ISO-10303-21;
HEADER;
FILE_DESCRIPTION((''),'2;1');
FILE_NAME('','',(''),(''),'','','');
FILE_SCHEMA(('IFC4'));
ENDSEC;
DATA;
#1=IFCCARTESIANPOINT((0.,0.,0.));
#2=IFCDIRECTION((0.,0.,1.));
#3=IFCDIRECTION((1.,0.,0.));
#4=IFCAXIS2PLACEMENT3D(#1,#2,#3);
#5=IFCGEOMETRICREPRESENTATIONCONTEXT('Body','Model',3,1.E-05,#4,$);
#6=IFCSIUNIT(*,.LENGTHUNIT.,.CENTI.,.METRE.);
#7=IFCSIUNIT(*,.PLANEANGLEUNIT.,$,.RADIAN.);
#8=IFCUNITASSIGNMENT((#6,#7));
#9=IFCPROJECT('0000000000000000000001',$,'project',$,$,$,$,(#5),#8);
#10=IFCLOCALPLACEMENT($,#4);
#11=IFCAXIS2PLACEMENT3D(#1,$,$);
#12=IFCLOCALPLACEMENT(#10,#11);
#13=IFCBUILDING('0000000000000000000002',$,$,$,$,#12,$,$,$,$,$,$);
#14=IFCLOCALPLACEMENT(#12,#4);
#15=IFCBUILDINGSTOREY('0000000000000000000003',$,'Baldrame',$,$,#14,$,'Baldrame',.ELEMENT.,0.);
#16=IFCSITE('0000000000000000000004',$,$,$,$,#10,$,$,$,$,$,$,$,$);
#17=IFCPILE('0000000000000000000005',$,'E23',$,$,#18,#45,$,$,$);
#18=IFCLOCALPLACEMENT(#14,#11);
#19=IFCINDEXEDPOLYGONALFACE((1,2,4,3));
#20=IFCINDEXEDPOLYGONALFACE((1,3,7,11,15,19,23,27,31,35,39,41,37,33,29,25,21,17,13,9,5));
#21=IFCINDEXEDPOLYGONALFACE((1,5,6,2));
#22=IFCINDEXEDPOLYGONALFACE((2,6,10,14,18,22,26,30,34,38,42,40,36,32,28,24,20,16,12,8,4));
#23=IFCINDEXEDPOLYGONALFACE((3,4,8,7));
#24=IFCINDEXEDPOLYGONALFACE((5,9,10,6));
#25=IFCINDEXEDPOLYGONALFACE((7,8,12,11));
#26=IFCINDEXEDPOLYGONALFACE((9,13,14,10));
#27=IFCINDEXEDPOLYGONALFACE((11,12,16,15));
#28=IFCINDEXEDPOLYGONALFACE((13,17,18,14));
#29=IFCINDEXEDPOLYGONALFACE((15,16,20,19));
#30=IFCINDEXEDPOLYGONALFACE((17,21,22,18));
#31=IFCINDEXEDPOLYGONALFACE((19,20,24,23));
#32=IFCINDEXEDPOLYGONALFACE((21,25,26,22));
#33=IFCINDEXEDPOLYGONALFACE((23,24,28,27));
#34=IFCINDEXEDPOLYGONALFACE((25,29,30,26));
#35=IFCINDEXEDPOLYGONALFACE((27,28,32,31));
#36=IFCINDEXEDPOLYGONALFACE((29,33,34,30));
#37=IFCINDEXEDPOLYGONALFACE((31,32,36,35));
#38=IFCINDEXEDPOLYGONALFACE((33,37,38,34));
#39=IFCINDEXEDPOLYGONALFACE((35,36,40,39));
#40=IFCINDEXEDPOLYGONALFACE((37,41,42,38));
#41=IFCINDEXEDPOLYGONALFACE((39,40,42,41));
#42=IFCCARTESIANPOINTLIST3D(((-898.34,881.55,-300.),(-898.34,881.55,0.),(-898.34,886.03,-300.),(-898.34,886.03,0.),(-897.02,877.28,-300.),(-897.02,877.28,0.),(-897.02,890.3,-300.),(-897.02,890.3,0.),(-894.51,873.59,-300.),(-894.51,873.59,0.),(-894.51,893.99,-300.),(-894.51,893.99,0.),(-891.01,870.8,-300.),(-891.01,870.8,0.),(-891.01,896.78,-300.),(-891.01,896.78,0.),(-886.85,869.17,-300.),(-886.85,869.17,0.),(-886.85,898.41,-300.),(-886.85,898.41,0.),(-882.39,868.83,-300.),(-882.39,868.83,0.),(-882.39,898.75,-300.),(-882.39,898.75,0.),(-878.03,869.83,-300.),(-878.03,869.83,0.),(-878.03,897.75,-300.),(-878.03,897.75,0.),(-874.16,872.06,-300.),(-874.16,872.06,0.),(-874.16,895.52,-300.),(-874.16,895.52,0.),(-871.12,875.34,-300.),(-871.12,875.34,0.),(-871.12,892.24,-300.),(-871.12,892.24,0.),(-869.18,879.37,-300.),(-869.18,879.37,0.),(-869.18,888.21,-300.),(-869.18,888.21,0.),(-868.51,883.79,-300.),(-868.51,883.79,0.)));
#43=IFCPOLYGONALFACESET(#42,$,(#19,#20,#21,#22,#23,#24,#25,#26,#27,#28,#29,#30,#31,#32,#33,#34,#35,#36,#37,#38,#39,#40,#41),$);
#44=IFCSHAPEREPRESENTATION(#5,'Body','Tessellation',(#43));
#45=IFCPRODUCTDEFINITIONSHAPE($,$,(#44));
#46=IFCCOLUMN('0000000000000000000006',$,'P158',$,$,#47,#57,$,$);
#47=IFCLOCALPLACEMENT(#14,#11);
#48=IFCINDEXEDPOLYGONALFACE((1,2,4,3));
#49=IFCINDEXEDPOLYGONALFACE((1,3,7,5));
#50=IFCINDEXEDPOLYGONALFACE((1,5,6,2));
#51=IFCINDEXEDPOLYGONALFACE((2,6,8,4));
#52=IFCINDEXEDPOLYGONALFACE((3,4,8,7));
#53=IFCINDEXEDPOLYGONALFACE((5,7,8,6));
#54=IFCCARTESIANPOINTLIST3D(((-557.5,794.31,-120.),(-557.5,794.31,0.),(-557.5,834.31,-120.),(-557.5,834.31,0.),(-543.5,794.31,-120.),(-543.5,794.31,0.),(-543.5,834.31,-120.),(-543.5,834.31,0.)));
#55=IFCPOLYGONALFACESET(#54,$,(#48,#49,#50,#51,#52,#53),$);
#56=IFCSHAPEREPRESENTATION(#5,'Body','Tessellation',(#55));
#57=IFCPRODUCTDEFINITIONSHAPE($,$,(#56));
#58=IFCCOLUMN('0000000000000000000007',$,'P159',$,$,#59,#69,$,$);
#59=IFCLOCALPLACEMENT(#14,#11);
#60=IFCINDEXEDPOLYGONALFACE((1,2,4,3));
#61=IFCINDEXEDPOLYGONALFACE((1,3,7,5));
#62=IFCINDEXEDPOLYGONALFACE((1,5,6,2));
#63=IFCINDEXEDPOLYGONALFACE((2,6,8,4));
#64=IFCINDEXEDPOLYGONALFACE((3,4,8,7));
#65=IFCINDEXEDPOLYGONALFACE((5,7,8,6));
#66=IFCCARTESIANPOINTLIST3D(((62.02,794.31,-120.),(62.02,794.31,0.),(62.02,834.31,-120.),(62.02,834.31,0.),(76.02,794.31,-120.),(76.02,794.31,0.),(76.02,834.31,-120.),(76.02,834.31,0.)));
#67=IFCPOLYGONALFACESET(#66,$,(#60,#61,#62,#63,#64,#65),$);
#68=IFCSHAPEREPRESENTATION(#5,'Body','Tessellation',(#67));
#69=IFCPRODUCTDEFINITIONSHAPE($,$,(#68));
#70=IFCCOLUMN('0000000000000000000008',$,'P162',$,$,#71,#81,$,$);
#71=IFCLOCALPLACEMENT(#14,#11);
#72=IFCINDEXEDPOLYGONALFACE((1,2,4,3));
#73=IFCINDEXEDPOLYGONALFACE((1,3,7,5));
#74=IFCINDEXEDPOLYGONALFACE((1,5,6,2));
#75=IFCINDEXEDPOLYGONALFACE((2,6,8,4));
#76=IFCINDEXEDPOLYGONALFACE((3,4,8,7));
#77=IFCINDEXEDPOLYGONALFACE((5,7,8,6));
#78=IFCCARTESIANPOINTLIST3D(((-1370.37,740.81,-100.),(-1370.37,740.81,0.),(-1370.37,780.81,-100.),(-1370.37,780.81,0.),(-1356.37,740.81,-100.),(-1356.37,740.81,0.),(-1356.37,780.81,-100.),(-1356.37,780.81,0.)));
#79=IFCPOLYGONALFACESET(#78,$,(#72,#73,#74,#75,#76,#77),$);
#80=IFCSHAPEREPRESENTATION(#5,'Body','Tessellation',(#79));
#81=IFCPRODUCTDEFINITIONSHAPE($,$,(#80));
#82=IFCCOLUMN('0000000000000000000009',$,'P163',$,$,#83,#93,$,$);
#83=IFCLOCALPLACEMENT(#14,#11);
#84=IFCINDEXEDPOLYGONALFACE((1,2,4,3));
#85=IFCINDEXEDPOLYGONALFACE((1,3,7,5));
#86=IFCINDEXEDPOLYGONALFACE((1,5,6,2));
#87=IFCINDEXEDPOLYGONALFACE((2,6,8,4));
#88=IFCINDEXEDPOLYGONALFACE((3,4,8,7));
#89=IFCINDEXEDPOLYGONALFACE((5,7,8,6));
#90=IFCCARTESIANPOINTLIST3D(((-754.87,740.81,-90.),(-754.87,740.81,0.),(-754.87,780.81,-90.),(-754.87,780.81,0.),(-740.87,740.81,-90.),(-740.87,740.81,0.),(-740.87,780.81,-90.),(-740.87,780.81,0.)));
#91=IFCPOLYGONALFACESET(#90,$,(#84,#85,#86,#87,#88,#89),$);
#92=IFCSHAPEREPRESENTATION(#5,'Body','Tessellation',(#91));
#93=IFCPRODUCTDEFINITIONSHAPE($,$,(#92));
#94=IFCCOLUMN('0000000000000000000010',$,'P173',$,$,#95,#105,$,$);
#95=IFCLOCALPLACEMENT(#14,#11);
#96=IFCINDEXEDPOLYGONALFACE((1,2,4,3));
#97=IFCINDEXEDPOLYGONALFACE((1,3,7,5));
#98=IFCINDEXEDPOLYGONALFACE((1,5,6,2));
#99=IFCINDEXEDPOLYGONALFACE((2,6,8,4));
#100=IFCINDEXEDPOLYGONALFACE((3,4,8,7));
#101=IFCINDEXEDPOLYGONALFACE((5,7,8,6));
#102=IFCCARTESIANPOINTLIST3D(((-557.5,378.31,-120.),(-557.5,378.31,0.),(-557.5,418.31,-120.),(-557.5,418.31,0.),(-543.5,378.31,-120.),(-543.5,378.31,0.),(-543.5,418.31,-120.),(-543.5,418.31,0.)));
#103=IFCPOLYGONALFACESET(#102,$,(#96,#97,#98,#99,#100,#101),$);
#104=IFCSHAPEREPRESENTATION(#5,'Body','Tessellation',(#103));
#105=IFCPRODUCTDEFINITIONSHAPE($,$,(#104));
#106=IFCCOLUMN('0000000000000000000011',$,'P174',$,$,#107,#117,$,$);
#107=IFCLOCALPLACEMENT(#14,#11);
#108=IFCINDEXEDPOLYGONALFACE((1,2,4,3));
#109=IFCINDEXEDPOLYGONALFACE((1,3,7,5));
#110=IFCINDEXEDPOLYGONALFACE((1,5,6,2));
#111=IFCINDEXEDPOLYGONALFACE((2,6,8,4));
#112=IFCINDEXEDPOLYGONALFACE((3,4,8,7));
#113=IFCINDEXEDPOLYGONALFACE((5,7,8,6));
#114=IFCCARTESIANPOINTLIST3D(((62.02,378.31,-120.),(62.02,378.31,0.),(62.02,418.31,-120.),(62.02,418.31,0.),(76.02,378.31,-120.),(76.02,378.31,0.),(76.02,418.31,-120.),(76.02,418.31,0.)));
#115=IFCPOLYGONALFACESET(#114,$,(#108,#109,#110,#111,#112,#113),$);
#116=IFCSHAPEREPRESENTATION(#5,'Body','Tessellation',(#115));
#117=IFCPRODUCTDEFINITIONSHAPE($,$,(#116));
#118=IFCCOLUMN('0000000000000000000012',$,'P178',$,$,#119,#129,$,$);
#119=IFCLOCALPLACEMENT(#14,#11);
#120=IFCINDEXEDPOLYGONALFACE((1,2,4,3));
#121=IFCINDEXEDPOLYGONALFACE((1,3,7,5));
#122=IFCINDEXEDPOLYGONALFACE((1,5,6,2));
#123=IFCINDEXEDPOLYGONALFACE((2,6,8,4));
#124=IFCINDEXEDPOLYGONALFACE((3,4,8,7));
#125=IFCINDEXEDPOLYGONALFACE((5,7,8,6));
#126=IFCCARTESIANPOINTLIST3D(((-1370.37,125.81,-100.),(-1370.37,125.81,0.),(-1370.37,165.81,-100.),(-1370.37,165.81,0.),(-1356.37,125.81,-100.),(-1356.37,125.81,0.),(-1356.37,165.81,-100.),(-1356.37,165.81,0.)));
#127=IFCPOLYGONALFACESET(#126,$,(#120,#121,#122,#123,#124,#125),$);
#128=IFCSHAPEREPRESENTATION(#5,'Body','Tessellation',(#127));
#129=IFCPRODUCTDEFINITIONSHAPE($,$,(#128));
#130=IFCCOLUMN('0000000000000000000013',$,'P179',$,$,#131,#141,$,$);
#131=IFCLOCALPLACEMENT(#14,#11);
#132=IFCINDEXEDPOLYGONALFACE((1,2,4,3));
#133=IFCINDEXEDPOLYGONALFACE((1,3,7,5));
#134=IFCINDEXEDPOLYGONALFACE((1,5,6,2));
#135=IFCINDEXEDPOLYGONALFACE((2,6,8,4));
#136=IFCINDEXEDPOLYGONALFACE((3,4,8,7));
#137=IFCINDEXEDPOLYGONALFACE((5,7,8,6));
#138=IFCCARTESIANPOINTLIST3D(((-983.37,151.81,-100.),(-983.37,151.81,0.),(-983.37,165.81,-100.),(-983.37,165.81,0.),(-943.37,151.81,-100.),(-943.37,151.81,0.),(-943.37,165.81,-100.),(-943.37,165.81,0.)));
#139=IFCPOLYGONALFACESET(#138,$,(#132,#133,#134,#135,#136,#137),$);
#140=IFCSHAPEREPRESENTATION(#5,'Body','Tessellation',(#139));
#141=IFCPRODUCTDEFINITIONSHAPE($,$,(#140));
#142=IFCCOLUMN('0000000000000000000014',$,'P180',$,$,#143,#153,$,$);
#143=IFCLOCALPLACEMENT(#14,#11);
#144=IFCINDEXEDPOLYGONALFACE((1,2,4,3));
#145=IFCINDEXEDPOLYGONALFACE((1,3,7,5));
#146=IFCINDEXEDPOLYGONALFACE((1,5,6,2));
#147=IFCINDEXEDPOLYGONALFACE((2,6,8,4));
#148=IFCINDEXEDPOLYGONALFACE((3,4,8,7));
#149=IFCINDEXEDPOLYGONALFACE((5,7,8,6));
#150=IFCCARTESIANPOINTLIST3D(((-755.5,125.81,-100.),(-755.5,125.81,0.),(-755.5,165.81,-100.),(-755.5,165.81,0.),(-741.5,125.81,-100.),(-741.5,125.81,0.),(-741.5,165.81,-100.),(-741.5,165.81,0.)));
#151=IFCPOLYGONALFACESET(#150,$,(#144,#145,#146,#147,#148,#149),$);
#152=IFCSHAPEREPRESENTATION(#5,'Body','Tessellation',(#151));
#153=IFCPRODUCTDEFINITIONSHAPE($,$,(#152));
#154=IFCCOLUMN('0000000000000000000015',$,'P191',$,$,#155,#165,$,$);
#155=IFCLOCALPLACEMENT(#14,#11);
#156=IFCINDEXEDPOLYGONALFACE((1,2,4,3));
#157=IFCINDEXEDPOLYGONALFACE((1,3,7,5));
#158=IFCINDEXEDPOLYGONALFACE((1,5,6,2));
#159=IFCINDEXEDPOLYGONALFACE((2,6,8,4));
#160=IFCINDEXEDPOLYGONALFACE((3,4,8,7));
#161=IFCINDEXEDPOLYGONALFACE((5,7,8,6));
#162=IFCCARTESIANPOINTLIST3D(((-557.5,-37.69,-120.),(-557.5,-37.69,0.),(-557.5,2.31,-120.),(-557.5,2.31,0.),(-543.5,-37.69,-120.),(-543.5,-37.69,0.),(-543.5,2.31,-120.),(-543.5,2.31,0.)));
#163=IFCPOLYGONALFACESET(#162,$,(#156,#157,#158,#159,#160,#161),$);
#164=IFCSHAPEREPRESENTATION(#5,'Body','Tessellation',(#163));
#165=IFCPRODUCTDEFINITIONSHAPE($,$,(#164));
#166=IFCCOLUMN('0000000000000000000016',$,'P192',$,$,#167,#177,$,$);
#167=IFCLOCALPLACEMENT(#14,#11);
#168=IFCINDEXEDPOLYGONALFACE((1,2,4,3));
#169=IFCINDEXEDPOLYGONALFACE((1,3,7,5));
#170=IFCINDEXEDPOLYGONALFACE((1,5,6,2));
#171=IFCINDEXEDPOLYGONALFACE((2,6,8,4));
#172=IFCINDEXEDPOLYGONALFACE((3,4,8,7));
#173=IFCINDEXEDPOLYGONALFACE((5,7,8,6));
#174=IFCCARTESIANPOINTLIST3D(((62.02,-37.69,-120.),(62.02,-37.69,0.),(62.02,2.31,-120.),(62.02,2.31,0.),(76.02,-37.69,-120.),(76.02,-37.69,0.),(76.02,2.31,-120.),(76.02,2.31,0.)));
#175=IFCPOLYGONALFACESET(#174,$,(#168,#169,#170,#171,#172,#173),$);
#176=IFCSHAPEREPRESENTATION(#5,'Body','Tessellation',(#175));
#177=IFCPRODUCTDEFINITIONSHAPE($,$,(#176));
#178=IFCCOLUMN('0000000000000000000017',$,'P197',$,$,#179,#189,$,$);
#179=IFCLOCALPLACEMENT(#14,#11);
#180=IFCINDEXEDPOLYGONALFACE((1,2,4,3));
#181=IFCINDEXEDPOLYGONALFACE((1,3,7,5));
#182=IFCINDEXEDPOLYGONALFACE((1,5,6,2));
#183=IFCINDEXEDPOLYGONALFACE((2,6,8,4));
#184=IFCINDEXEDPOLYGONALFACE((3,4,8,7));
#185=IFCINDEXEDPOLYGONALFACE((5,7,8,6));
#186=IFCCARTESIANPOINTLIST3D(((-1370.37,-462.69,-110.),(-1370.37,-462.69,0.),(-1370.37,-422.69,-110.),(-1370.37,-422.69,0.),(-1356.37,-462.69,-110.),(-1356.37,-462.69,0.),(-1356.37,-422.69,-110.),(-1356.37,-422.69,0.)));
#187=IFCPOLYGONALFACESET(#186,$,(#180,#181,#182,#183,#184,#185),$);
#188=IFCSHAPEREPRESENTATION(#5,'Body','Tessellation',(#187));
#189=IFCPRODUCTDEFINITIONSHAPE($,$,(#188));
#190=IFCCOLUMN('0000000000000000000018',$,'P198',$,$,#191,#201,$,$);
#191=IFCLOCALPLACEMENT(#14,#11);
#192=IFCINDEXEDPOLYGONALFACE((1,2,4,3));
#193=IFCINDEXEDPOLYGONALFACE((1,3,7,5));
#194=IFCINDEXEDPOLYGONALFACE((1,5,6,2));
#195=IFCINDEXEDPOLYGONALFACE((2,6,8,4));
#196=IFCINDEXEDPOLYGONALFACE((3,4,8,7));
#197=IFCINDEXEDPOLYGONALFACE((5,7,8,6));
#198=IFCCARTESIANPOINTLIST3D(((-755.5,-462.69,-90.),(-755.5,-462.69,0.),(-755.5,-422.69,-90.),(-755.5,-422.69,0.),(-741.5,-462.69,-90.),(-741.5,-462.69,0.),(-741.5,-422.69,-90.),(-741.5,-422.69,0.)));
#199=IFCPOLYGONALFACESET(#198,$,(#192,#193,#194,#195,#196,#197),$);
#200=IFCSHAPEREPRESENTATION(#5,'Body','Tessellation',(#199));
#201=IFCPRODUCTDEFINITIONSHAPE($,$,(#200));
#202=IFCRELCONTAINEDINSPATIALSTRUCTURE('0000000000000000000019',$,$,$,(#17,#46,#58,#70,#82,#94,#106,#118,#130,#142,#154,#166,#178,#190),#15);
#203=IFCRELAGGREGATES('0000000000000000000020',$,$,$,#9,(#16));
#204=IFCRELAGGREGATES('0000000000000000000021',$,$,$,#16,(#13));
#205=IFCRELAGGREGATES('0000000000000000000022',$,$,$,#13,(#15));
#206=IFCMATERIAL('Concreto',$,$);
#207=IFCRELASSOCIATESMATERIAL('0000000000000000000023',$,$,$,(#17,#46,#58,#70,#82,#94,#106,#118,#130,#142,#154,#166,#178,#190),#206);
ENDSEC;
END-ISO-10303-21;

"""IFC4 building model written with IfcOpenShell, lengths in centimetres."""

from ifc_helpers import new_model, si_unit, frame, origin, origin_with_axes, origin_2d_with_axis, place, context, project, spatial, rectangle, circle, extrude, material, element, save


model = new_model("IFC4")

# Units and contexts
model_context = context("Model", 3, precision=1e-05, world=origin_with_axes(), identifier="Body")
ifc_project = project(units=[si_unit("LENGTHUNIT", "METRE", prefix="CENTI"), si_unit("PLANEANGLEUNIT", "RADIAN")], contexts=[model_context])

# Site, building, storey
site_placement = place(None, origin_with_axes())
site = spatial("IfcSite", under=ifc_project, at=site_placement)
building_placement = place(site_placement, origin())
building = spatial("IfcBuilding", under=site, at=building_placement)
storey_placement = place(building_placement, origin_with_axes())
storey = spatial("IfcBuildingStorey", under=building, at=storey_placement, Name="Baldrame", LongName="Baldrame", CompositionType="ELEMENT", Elevation=0.0)

# Pile
ifc_material = material(Name="Concreto")
pile_placement = place(storey_placement, frame((-883.51, 883.79, 0.0), z_axis=(0.0, 0.0, 1.0), x_axis=(1.0, 0.0, 0.0)))
element("IfcPile", 1, at=pile_placement, inside=storey, material=ifc_material, Name="E23", context=model_context, shape_type="SolidModel", body=[
    extrude(circle(Radius=15.0, at=origin_2d_with_axis()), frame((0.0, 0.0, -300.0), z_axis=(0.0, 0.0, 1.0), x_axis=(1.0, 0.0, 0.0)), (0.0, 0.0, 1.0), 300.0),
])

# Columns
for number, where, z_axis, x_axis, name in (
    (2, (-550.5, 814.31, 0.0), (0.0, 0.0, 1.0), (1.0, 0.0, 0.0), "P158"),
    (3, (69.02, 814.31, 0.0), (0.0, 0.0, 1.0), (1.0, 0.0, 0.0), "P159"),
):
    element("IfcColumn", number, at=place(storey_placement, frame(where, z_axis=z_axis, x_axis=x_axis)), inside=storey, material=ifc_material, Name=name, context=model_context, shape_type="SolidModel", body=[
        extrude(rectangle(XDim=14.0, YDim=40.0, at=origin_2d_with_axis()), frame((0.0, 0.0, -120.0), z_axis=(0.0, 0.0, 1.0), x_axis=(1.0, 0.0, 0.0)), (0.0, 0.0, 1.0), 120.0),
    ])
column_1_placement = place(storey_placement, frame((-1363.37, 760.81, 0.0), z_axis=(0.0, 0.0, 1.0), x_axis=(1.0, 0.0, 0.0)))
element("IfcColumn", 4, at=column_1_placement, inside=storey, material=ifc_material, Name="P162", context=model_context, shape_type="SolidModel", body=[
    extrude(rectangle(XDim=14.0, YDim=40.0, at=origin_2d_with_axis()), frame((0.0, 0.0, -100.0), z_axis=(0.0, 0.0, 1.0), x_axis=(1.0, 0.0, 0.0)), (0.0, 0.0, 1.0), 100.0),
])
column_2_placement = place(storey_placement, frame((-747.87, 760.81, 0.0), z_axis=(0.0, 0.0, 1.0), x_axis=(1.0, 0.0, 0.0)))
element("IfcColumn", 5, at=column_2_placement, inside=storey, material=ifc_material, Name="P163", context=model_context, shape_type="SolidModel", body=[
    extrude(rectangle(XDim=14.0, YDim=40.0, at=origin_2d_with_axis()), frame((0.0, 0.0, -90.0), z_axis=(0.0, 0.0, 1.0), x_axis=(1.0, 0.0, 0.0)), (0.0, 0.0, 1.0), 90.0),
])
for number, where, z_axis, x_axis, name in (
    (6, (-550.5, 398.31, 0.0), (0.0, 0.0, 1.0), (1.0, 0.0, 0.0), "P173"),
    (7, (69.02, 398.31, 0.0), (0.0, 0.0, 1.0), (1.0, 0.0, 0.0), "P174"),
):
    element("IfcColumn", number, at=place(storey_placement, frame(where, z_axis=z_axis, x_axis=x_axis)), inside=storey, material=ifc_material, Name=name, context=model_context, shape_type="SolidModel", body=[
        extrude(rectangle(XDim=14.0, YDim=40.0, at=origin_2d_with_axis()), frame((0.0, 0.0, -120.0), z_axis=(0.0, 0.0, 1.0), x_axis=(1.0, 0.0, 0.0)), (0.0, 0.0, 1.0), 120.0),
    ])
column_3_placement = place(storey_placement, frame((-1363.37, 145.81, 0.0), z_axis=(0.0, 0.0, 1.0), x_axis=(1.0, 0.0, 0.0)))
element("IfcColumn", 8, at=column_3_placement, inside=storey, material=ifc_material, Name="P178", context=model_context, shape_type="SolidModel", body=[
    extrude(rectangle(XDim=14.0, YDim=40.0, at=origin_2d_with_axis()), frame((0.0, 0.0, -100.0), z_axis=(0.0, 0.0, 1.0), x_axis=(1.0, 0.0, 0.0)), (0.0, 0.0, 1.0), 100.0),
])
column_4_placement = place(storey_placement, frame((-963.37, 158.81, 0.0), z_axis=(0.0, 0.0, 1.0), x_axis=(1.0, 0.0, 0.0)))
element("IfcColumn", 9, at=column_4_placement, inside=storey, material=ifc_material, Name="P179", context=model_context, shape_type="SolidModel", body=[
    extrude(rectangle(XDim=14.0, YDim=40.0, at=origin_2d_with_axis()), frame((0.0, 0.0, -100.0), z_axis=(0.0, 0.0, 1.0), x_axis=(0.0, -1.0, 0.0)), (0.0, 0.0, 1.0), 100.0),
])
column_5_placement = place(storey_placement, frame((-748.5, 145.81, 0.0), z_axis=(0.0, 0.0, 1.0), x_axis=(1.0, 0.0, 0.0)))
element("IfcColumn", 10, at=column_5_placement, inside=storey, material=ifc_material, Name="P180", context=model_context, shape_type="SolidModel", body=[
    extrude(rectangle(XDim=14.0, YDim=40.0, at=origin_2d_with_axis()), frame((0.0, 0.0, -100.0), z_axis=(0.0, 0.0, 1.0), x_axis=(1.0, 0.0, 0.0)), (0.0, 0.0, 1.0), 100.0),
])
for number, where, z_axis, x_axis, name in (
    (11, (-550.5, -17.69, 0.0), (0.0, 0.0, 1.0), (1.0, 0.0, 0.0), "P191"),
    (12, (69.02, -17.69, 0.0), (0.0, 0.0, 1.0), (1.0, 0.0, 0.0), "P192"),
):
    element("IfcColumn", number, at=place(storey_placement, frame(where, z_axis=z_axis, x_axis=x_axis)), inside=storey, material=ifc_material, Name=name, context=model_context, shape_type="SolidModel", body=[
        extrude(rectangle(XDim=14.0, YDim=40.0, at=origin_2d_with_axis()), frame((0.0, 0.0, -120.0), z_axis=(0.0, 0.0, 1.0), x_axis=(1.0, 0.0, 0.0)), (0.0, 0.0, 1.0), 120.0),
    ])
column_6_placement = place(storey_placement, frame((-1363.37, -442.69, 0.0), z_axis=(0.0, 0.0, 1.0), x_axis=(1.0, 0.0, 0.0)))
element("IfcColumn", 13, at=column_6_placement, inside=storey, material=ifc_material, Name="P197", context=model_context, shape_type="SolidModel", body=[
    extrude(rectangle(XDim=14.0, YDim=40.0, at=origin_2d_with_axis()), frame((0.0, 0.0, -110.0), z_axis=(0.0, 0.0, 1.0), x_axis=(1.0, 0.0, 0.0)), (0.0, 0.0, 1.0), 110.0),
])
column_7_placement = place(storey_placement, frame((-748.5, -442.69, 0.0), z_axis=(0.0, 0.0, 1.0), x_axis=(1.0, 0.0, 0.0)))
element("IfcColumn", 14, at=column_7_placement, inside=storey, material=ifc_material, Name="P198", context=model_context, shape_type="SolidModel", body=[
    extrude(rectangle(XDim=14.0, YDim=40.0, at=origin_2d_with_axis()), frame((0.0, 0.0, -90.0), z_axis=(0.0, 0.0, 1.0), x_axis=(1.0, 0.0, 0.0)), (0.0, 0.0, 1.0), 90.0),
])

save(model, "model.ifc")
